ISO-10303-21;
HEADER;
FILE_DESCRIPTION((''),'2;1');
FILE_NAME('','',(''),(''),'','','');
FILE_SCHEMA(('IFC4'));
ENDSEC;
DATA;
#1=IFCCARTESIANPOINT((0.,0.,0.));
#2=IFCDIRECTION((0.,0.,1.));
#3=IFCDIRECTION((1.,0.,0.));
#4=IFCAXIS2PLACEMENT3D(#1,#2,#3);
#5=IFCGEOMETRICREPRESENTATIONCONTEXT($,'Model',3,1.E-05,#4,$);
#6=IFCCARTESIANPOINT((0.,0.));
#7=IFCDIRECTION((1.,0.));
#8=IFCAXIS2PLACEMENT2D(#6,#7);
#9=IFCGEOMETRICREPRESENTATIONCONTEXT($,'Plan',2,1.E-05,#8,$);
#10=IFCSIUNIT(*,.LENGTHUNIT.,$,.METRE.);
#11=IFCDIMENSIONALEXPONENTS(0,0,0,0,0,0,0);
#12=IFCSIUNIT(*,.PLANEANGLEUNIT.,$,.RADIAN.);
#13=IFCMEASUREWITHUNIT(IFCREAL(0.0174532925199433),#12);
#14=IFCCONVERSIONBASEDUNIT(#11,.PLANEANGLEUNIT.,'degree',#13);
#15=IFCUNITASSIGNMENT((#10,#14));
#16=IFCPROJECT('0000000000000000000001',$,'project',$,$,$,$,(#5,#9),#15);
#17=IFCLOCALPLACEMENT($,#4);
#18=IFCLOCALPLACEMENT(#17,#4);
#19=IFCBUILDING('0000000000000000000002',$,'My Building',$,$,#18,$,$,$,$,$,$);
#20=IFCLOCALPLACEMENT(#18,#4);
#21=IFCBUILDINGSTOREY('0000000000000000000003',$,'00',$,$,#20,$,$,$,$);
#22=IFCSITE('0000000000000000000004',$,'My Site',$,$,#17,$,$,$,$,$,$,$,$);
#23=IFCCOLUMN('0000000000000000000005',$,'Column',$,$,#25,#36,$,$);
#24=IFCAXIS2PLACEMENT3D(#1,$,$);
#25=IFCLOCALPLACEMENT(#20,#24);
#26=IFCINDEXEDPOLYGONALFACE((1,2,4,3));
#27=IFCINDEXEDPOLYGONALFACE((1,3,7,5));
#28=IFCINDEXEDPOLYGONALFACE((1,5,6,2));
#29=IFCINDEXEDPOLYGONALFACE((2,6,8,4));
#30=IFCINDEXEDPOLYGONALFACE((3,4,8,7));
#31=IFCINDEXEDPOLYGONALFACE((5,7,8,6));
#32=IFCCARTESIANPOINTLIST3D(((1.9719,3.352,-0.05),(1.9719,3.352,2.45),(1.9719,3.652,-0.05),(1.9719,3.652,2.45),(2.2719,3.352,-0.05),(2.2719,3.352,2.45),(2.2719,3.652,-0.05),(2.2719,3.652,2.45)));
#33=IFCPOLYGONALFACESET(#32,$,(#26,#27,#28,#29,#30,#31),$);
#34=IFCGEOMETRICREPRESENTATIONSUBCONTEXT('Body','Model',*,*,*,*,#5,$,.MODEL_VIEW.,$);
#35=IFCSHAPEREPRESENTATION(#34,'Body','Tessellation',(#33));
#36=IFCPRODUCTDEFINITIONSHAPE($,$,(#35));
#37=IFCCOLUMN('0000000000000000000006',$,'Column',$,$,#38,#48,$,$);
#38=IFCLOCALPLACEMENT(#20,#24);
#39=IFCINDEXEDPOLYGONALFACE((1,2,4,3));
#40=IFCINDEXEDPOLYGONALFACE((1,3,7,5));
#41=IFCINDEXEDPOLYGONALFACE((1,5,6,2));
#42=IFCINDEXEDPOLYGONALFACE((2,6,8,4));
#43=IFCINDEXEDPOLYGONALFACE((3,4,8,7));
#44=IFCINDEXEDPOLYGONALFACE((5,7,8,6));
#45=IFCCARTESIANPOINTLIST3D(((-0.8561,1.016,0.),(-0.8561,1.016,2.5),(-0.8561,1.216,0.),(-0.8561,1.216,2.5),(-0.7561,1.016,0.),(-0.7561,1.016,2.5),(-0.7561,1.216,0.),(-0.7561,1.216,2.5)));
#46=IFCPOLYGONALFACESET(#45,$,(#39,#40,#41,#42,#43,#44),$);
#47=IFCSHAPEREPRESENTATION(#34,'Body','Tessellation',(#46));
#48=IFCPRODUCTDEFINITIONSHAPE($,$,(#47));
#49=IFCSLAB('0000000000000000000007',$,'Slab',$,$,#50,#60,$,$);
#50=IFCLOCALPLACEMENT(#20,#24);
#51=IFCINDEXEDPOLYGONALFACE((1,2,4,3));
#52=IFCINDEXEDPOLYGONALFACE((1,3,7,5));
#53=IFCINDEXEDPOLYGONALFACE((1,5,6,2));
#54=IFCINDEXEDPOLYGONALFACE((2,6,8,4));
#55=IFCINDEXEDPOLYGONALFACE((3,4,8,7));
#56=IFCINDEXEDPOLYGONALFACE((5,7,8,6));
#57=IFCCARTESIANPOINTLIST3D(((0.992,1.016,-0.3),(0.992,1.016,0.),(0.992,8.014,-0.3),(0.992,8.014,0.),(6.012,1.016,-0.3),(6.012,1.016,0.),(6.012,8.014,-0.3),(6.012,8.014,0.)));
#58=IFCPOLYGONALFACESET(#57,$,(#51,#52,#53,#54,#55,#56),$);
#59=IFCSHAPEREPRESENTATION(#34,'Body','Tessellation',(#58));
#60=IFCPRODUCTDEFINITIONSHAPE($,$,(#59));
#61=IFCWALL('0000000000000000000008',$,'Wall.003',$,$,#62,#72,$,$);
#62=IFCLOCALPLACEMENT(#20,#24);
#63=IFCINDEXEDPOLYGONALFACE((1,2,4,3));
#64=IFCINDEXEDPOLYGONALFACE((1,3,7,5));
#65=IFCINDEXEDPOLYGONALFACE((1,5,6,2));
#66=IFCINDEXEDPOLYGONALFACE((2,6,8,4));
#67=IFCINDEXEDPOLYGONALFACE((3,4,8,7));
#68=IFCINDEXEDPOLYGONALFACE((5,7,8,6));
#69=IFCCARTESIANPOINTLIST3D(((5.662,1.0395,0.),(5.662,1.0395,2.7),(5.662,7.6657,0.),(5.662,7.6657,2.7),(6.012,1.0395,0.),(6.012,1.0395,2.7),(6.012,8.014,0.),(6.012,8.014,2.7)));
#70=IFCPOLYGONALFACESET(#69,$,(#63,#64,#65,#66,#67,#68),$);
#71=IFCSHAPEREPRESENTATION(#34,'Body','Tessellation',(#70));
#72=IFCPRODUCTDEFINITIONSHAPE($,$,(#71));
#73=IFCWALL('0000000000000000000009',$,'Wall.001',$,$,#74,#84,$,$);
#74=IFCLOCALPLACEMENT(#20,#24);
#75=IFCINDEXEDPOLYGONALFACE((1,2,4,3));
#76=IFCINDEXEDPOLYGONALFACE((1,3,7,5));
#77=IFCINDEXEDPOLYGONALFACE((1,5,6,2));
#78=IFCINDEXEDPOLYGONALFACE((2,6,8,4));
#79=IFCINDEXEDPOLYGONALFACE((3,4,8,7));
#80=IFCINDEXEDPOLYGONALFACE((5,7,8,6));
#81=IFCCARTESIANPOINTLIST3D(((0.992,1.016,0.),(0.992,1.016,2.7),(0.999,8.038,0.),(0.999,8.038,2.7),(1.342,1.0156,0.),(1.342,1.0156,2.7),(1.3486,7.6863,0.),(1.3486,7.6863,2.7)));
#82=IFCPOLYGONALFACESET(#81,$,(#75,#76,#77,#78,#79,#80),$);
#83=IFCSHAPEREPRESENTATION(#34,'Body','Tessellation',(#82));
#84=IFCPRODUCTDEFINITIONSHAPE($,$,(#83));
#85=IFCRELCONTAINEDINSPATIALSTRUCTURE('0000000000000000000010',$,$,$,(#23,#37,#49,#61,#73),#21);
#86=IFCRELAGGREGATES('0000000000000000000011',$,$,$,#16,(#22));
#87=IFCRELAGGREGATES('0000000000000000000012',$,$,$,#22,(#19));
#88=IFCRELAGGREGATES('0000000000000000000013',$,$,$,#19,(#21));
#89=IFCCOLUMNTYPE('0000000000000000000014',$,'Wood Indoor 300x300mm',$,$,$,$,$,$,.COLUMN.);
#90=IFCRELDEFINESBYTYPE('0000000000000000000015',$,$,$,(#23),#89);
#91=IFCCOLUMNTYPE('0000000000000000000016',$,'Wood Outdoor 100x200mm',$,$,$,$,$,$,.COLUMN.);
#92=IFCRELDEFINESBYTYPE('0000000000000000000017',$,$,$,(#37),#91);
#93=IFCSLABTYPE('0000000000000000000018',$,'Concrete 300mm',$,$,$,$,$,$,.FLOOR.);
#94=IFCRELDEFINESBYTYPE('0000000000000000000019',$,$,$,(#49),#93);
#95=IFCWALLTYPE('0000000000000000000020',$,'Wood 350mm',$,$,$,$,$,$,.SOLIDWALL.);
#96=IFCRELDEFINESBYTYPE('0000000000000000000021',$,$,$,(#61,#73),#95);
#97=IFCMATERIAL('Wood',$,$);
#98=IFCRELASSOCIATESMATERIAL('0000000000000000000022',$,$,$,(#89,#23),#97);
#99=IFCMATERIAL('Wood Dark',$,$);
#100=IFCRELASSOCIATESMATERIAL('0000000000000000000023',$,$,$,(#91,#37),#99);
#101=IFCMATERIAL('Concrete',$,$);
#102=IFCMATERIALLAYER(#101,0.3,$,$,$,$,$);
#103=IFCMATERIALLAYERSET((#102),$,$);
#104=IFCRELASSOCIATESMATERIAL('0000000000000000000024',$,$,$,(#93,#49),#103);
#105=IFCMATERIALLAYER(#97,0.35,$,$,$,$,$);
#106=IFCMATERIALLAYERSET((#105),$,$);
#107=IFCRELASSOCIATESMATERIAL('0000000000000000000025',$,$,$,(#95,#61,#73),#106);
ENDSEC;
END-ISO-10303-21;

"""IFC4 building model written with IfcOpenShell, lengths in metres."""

from ifc_helpers import new_model, entity, si_unit, converted_unit, frame, origin_with_axes, origin_2d_with_axis, place, context, subcontext, project, spatial, line, indexed_curve, rectangle, outline, extrude, clip, halfspace, material, layer, layer_set, layer_usage, material_profile, profile_set, profile_usage, type_object, element, save


model = new_model("IFC4")

# Units and contexts
model_context = context("Model", 3, precision=1e-05, world=origin_with_axes())
plan_context = context("Plan", 2, precision=1e-05, world=origin_2d_with_axis())
body_context = subcontext(model_context, "Body", "Model", "MODEL_VIEW")
ifc_project = project(units=[si_unit("LENGTHUNIT", "METRE"), converted_unit("PLANEANGLEUNIT", "degree", entity("IfcReal", 0.0174532925199433), si_unit("PLANEANGLEUNIT", "RADIAN"), dimensions=[0, 0, 0, 0, 0, 0, 0])], contexts=[model_context, plan_context])

# Site, building, storey
site_placement = place(None, origin_with_axes())
site = spatial("IfcSite", under=ifc_project, at=site_placement, Name="My Site")
building_placement = place(site_placement, origin_with_axes())
building = spatial("IfcBuilding", under=site, at=building_placement, Name="My Building")
storey_placement = place(building_placement, origin_with_axes())
storey = spatial("IfcBuildingStorey", under=building, at=storey_placement, Name="00")

# Columns
ifc_material_1 = material(Name="Wood")
ifc_material_profile_1 = material_profile(ifc_material_1, rectangle(XDim=0.3, YDim=0.3))
ifc_profile_set_1 = profile_set([ifc_material_profile_1])
ifc_profile_usage_1 = profile_usage(ifc_profile_set_1, cardinal=5)
column_type_1 = type_object("IfcColumnType", Name="Wood Indoor 300x300mm", PredefinedType="COLUMN", material=ifc_profile_set_1)
column_1_placement = place(storey_placement, frame((2.1219, 3.502, -0.05), z_axis=(0.0, 0.0, 1.0), x_axis=(1.0, 0.0, 0.0)))
element("IfcColumn", 1, at=column_1_placement, inside=storey, type_object=column_type_1, material=ifc_profile_usage_1, Name="Column", context=body_context, shape_type="SweptSolid", body=[
    extrude(rectangle(XDim=0.3, YDim=0.3), origin_with_axes(), (0.0, 0.0, 1.0), 2.5),
])
ifc_material_2 = material(Name="Wood Dark")
ifc_material_profile_2 = material_profile(ifc_material_2, rectangle(XDim=0.1, YDim=0.2, kind="CURVE"))
ifc_profile_set_2 = profile_set([ifc_material_profile_2])
ifc_profile_usage_2 = profile_usage(ifc_profile_set_2, cardinal=1)
column_type_2 = type_object("IfcColumnType", Name="Wood Outdoor 100x200mm", PredefinedType="COLUMN", material=ifc_profile_set_2)
column_2_placement = place(storey_placement, frame((-0.7561, 1.016, 0.0), z_axis=(0.0, 0.0, 1.0), x_axis=(1.0, 0.0, 0.0)))
element("IfcColumn", 2, at=column_2_placement, inside=storey, type_object=column_type_2, material=ifc_profile_usage_2, Name="Column", context=body_context, shape_type="SweptSolid", body=[
    extrude(rectangle(XDim=0.1, YDim=0.2, kind="CURVE"), frame((-0.05, 0.1, 0.0), z_axis=(0.0, 0.0, 1.0), x_axis=(1.0, 0.0, 0.0)), (0.0, 0.0, 1.0), 2.5),
])

# Slab
ifc_material_3 = material(Name="Concrete")
ifc_layer_1 = layer(ifc_material_3, 0.3)
ifc_layer_set_1 = layer_set([ifc_layer_1])
ifc_layer_usage_1 = layer_usage(ifc_layer_set_1, "AXIS3", "POSITIVE", 0.0)
slab_type = type_object("IfcSlabType", Name="Concrete 300mm", PredefinedType="FLOOR", material=ifc_layer_set_1)
slab_placement = place(storey_placement, frame((0.992, 1.016, -0.3), z_axis=(0.0, 0.0, 1.0), x_axis=(1.0, 0.0, 0.0)))
element("IfcSlab", 3, at=slab_placement, inside=storey, type_object=slab_type, material=ifc_layer_usage_1, Name="Slab", context=body_context, shape_type="SweptSolid", body=[
    extrude(outline(indexed_curve([(0.0, 0.0), (5.02, 0.0), (5.02, 6.998), (0.0, 6.998)], segments=[line(4, 3), line(3, 2), line(2, 1), line(1, 4)], self_intersect=False)), None, (0.0, 0.0, 1.0), 0.3),
])

# Walls
ifc_layer_2 = layer(ifc_material_1, 0.35)
ifc_layer_set_2 = layer_set([ifc_layer_2])
ifc_layer_usage_2 = layer_usage(ifc_layer_set_2, "AXIS2", "POSITIVE", 0.0)
wall_type = type_object("IfcWallType", Name="Wood 350mm", PredefinedType="SOLIDWALL", material=ifc_layer_set_2)
wall_1_placement = place(storey_placement, frame((6.012, 1.0395, 0.0), z_axis=(0.0, 0.0, 1.0), x_axis=(0.0, 1.0, 0.0)))
element("IfcWall", 4, at=wall_1_placement, inside=storey, type_object=wall_type, material=ifc_layer_usage_2, Name="Wall.003", context=body_context, shape_type="Clipping", body=[
    clip(extrude(outline(indexed_curve([(0.0, 0.0), (0.0, 0.35), (6.9762, 0.35), (6.9762, 0.0), (0.0, 0.0)], self_intersect=False)), origin_with_axes(), (0.0, 0.0, 1.0), 2.7), halfspace(frame((6.9745, 0.0, 0.0), z_axis=(0.708799, 0.705411, 0.0), x_axis=(0.705411, -0.708799, 0.0)), False)),
])
ifc_layer_usage_3 = layer_usage(ifc_layer_set_2, "AXIS2", "POSITIVE", 0.0)
wall_2_placement = place(storey_placement, frame((0.999, 8.038, 0.0), z_axis=(0.0, 0.0, 1.0), x_axis=(-0.000997, -1.0, 0.0)))
element("IfcWall", 5, at=wall_2_placement, inside=storey, type_object=wall_type, material=ifc_layer_usage_3, Name="Wall.001", context=body_context, shape_type="Clipping", body=[
    clip(extrude(outline(indexed_curve([(0.0, 0.0), (0.0, 0.35), (7.022, 0.35), (7.022, 0.0), (0.0, 0.0)], self_intersect=False)), origin_with_axes(), (0.0, 0.0, 1.0), 2.7), halfspace(frame((0.0, 0.0, 0.0), z_axis=(-0.705766, 0.708445, 0.0), x_axis=(0.708445, 0.705766, 0.0)), False)),
])

save(model, "model.ifc")
